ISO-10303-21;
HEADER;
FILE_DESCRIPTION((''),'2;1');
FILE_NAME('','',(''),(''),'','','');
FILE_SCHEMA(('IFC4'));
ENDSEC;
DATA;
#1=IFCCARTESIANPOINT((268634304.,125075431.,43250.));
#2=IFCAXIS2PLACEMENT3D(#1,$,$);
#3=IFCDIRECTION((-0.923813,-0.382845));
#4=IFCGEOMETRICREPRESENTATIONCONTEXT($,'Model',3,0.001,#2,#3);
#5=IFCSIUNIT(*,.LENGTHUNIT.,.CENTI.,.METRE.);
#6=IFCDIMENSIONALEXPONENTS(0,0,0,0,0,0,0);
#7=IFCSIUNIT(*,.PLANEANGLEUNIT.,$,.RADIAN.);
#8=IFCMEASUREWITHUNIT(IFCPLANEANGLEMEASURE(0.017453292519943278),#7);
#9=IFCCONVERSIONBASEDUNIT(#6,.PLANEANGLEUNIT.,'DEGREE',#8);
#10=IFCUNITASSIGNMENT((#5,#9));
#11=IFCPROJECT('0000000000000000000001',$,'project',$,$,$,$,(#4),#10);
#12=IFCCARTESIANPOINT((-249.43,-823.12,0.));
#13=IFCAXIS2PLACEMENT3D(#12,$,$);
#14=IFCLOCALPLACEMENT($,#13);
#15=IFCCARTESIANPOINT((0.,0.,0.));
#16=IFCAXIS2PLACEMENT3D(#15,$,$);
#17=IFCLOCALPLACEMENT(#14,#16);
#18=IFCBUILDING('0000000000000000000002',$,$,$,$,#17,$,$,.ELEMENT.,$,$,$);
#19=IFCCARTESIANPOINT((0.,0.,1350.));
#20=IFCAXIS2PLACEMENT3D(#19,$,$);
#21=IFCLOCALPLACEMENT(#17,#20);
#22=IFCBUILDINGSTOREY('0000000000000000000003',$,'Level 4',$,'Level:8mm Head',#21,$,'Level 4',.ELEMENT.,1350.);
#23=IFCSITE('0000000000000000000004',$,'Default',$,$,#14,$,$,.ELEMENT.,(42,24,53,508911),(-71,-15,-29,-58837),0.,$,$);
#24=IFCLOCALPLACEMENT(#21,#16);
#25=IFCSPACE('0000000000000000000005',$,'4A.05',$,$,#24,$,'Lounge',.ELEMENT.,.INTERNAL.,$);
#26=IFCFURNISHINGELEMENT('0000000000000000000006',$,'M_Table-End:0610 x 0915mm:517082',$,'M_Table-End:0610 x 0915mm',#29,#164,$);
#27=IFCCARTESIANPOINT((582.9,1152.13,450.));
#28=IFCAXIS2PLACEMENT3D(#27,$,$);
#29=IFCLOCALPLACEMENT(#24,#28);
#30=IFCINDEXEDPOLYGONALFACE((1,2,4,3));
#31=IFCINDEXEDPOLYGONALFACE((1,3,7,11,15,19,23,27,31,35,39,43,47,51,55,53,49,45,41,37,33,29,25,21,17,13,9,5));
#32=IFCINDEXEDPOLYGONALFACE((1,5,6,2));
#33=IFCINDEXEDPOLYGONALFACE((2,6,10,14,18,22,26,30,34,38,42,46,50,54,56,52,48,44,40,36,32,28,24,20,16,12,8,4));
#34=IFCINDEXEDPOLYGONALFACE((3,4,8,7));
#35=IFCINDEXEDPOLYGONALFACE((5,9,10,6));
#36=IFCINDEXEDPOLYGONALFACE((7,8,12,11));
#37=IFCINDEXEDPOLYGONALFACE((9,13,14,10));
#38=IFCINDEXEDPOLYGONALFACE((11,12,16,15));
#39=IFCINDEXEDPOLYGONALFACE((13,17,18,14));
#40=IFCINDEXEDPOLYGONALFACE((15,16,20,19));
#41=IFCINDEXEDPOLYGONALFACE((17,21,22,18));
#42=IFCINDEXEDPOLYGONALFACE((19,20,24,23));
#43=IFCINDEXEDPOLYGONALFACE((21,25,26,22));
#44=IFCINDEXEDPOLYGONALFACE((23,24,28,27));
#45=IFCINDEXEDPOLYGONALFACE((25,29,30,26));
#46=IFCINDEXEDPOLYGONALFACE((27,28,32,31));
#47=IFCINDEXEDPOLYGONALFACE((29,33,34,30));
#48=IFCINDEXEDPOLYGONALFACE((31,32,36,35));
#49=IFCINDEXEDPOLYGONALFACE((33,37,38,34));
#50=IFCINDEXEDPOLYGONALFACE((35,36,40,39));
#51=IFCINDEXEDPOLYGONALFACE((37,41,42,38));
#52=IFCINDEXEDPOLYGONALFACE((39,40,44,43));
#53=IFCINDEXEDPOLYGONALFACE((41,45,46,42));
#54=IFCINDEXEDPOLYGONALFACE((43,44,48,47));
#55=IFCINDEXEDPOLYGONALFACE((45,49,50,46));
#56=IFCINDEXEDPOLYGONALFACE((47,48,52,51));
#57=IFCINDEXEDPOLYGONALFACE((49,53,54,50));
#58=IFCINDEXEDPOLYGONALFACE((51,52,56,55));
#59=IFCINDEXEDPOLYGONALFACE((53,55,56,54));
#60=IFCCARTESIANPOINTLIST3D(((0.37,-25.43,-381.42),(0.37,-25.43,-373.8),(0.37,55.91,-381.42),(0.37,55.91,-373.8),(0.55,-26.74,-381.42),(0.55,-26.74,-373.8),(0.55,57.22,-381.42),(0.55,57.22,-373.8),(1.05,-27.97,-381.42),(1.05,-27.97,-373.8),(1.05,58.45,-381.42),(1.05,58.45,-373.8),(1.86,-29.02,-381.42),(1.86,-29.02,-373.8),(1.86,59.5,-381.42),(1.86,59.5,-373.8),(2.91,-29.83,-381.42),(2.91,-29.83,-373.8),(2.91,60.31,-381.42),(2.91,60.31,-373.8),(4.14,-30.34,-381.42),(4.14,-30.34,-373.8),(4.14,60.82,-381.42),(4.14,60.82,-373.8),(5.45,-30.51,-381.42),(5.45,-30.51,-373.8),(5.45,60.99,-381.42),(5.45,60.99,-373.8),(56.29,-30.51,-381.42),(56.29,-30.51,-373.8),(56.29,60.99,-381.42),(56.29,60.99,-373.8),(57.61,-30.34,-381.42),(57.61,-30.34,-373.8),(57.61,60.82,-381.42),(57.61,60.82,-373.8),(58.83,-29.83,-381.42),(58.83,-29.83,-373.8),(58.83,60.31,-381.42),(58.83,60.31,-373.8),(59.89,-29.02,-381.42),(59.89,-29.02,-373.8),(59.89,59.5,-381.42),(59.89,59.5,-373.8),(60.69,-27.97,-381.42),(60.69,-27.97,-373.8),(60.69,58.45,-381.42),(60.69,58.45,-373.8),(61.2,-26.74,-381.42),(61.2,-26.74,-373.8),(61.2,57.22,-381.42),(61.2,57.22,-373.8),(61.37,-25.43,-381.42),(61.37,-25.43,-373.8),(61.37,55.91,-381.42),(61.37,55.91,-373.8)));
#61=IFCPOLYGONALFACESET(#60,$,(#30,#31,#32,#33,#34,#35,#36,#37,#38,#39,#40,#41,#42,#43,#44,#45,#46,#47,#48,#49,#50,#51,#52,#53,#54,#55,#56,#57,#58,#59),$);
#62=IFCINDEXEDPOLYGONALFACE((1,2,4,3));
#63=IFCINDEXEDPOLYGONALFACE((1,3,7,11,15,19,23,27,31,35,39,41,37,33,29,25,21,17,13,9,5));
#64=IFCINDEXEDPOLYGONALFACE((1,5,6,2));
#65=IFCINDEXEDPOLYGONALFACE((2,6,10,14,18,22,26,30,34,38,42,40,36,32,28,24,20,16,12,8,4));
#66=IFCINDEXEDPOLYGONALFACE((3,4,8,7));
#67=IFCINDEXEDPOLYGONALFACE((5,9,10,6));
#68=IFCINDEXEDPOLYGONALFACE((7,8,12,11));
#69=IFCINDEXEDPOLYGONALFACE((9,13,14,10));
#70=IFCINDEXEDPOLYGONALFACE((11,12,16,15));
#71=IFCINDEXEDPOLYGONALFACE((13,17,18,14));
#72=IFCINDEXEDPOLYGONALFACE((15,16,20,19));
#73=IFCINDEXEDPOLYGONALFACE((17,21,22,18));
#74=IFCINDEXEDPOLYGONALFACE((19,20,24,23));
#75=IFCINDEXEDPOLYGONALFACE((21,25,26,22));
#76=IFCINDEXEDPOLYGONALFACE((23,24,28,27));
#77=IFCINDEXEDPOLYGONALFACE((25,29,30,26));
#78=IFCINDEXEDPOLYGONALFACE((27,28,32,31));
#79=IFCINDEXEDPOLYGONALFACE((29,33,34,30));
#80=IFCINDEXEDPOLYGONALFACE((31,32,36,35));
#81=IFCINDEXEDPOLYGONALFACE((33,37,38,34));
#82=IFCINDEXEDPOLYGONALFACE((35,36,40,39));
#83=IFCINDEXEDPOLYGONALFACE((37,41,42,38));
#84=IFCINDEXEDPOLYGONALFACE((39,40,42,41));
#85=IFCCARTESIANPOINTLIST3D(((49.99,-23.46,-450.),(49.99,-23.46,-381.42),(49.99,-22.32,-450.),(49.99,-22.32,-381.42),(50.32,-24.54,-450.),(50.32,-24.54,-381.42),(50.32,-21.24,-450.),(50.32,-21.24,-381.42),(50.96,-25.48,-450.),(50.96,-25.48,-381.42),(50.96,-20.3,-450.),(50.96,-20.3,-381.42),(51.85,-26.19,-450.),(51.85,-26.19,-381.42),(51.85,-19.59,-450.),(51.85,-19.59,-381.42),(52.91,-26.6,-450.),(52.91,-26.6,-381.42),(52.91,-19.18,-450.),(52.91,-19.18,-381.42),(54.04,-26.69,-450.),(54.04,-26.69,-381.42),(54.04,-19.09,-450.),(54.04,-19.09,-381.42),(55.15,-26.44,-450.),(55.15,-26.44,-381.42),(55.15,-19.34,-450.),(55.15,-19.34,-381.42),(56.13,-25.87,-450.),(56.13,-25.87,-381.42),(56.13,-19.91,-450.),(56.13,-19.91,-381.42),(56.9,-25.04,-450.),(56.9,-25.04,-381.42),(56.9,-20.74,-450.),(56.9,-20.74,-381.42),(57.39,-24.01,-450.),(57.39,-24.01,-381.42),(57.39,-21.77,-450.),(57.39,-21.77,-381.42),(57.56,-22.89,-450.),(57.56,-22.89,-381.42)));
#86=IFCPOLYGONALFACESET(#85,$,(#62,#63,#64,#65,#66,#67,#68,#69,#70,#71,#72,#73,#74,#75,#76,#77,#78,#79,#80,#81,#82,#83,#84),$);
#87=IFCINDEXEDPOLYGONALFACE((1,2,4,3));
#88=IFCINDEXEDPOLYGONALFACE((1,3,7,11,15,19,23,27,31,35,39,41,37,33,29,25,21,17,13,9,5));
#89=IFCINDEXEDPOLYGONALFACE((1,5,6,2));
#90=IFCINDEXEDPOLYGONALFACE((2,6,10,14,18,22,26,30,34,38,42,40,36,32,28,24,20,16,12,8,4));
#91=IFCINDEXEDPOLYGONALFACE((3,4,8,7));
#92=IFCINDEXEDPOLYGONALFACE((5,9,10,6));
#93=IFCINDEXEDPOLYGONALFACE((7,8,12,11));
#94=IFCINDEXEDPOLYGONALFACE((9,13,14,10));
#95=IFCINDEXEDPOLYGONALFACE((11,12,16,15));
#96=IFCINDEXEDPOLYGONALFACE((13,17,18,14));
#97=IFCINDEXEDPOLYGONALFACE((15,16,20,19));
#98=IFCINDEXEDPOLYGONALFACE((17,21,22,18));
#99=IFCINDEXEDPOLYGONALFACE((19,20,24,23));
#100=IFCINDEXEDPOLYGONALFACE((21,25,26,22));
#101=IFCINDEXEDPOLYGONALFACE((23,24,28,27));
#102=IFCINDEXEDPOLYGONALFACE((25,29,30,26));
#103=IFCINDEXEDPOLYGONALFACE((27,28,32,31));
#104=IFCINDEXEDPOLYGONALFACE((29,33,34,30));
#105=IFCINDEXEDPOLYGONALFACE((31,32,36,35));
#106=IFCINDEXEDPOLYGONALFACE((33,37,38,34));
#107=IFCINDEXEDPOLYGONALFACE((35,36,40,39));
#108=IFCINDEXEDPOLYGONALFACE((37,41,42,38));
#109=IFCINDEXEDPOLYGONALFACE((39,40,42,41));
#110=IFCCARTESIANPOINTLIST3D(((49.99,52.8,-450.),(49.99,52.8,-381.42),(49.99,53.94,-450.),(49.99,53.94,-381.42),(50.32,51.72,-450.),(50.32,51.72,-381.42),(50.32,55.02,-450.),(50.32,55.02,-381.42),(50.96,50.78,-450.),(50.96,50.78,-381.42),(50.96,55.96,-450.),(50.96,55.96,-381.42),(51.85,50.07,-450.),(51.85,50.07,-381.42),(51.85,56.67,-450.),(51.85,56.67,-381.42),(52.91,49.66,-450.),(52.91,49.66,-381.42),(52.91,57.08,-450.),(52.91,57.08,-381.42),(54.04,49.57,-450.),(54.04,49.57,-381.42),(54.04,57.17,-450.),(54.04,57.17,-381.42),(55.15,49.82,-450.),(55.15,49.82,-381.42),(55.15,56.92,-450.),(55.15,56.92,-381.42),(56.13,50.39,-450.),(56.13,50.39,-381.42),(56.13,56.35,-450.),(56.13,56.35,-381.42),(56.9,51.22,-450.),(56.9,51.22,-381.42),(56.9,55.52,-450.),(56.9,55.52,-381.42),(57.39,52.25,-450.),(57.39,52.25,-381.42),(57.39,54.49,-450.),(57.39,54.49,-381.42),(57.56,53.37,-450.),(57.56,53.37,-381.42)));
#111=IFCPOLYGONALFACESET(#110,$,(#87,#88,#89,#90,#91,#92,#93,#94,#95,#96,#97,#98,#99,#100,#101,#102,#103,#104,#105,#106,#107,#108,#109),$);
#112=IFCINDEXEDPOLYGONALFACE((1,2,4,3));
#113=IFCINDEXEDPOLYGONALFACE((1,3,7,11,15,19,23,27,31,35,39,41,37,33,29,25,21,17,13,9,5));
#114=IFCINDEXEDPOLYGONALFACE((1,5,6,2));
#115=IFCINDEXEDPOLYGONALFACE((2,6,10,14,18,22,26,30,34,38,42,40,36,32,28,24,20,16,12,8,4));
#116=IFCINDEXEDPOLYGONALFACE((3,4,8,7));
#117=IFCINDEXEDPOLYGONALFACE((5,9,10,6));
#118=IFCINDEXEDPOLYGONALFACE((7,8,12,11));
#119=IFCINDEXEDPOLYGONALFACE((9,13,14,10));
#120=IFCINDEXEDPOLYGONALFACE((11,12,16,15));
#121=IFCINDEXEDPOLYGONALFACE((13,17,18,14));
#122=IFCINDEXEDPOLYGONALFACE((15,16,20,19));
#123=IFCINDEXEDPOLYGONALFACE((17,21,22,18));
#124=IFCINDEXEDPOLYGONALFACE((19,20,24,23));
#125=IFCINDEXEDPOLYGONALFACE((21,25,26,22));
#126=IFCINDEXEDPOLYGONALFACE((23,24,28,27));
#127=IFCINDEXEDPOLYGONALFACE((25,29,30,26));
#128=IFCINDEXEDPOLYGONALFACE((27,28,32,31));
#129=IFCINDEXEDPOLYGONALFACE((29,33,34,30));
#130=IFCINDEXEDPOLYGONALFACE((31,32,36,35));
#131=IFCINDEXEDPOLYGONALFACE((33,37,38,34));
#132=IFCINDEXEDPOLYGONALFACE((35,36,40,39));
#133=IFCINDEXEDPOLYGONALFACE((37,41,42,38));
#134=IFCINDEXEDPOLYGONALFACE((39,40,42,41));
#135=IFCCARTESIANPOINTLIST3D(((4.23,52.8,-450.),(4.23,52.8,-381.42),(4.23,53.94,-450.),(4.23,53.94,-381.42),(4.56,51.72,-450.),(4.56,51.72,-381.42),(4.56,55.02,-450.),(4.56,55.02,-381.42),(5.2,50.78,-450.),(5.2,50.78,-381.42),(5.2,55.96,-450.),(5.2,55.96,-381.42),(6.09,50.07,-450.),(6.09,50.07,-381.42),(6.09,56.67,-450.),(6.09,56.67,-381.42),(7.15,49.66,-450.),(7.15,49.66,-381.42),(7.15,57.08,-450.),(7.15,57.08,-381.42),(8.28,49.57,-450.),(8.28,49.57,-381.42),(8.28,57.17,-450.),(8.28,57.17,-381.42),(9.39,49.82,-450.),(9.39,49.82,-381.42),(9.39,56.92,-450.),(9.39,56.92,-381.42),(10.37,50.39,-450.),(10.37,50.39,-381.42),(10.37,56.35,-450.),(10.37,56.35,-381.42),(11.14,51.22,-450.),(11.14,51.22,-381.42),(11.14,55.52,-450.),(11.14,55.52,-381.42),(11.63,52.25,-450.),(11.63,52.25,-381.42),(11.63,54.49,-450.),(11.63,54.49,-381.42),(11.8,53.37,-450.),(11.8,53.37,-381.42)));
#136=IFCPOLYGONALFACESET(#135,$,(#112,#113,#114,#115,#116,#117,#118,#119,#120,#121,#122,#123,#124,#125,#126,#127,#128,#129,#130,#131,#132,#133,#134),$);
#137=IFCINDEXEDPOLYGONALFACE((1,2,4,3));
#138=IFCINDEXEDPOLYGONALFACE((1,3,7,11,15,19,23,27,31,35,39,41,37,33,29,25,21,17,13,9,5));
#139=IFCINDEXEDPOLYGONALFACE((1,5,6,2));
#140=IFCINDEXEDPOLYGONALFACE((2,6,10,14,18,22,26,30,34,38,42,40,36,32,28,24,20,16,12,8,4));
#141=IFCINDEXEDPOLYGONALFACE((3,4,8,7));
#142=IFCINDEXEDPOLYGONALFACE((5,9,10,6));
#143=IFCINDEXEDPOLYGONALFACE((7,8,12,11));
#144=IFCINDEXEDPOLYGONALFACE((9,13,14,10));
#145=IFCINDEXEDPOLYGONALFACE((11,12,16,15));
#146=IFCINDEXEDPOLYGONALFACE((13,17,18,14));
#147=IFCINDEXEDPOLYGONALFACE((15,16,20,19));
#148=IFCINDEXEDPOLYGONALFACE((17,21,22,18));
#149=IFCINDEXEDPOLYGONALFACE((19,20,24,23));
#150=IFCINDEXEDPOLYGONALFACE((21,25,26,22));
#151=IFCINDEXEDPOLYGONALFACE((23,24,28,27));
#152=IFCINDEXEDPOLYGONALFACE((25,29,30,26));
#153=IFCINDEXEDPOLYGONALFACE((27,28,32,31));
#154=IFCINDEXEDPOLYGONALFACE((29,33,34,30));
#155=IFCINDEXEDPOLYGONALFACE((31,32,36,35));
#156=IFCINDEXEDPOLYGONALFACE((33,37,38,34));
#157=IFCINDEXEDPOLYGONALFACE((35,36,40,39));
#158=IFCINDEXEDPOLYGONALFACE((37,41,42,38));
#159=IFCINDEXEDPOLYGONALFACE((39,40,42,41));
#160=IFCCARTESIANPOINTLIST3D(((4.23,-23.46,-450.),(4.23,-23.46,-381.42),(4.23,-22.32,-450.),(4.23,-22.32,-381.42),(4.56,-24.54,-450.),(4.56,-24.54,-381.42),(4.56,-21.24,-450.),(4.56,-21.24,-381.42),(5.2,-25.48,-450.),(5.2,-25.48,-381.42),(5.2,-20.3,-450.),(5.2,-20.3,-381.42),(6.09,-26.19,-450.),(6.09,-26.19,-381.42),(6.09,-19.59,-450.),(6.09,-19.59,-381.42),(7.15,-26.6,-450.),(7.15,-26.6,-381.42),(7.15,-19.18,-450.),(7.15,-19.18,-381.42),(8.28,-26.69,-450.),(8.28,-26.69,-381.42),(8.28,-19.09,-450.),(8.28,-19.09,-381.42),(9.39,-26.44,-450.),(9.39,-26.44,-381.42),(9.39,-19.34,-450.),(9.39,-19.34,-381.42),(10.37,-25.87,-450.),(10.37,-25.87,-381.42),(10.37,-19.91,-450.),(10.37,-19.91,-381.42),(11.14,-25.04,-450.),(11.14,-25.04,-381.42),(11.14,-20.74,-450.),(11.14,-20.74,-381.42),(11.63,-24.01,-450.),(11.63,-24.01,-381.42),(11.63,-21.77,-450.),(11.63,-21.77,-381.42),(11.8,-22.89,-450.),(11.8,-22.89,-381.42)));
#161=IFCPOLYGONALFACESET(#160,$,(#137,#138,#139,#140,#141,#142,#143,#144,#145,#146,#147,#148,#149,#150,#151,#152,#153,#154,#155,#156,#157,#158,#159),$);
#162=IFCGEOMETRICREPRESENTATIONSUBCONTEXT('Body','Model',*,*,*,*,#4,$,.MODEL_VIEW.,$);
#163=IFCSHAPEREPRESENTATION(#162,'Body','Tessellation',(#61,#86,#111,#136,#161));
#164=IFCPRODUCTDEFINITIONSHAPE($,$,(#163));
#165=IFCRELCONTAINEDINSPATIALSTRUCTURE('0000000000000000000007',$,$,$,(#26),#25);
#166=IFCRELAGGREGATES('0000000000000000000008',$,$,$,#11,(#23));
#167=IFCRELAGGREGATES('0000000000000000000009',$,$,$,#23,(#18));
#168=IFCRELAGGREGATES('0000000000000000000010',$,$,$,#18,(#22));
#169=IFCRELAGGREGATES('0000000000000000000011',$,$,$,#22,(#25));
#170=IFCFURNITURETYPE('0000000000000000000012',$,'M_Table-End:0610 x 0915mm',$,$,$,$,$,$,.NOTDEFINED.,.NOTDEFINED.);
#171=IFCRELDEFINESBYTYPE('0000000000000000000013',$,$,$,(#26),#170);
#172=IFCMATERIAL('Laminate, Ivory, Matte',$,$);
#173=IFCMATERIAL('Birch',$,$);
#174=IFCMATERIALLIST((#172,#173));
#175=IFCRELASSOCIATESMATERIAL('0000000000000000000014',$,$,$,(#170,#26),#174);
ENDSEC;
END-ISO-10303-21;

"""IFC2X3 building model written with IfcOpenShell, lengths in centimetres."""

from ifc_helpers import new_model, entity, si_unit, converted_unit, direction, frame, frame_2d, origin, place, context, subcontext, project, spatial, polyline, circle_curve, parameter, trimmed, segment, composite_curve, circle, outline, extrude, source, transform, mapped, material, material_list, type_object, type_shapes, element, save


model = new_model("IFC2X3")

# Units and contexts
model_context = context("Model", 3, precision=0.001, world=frame((268634304.0, 125075431.0, 43250.0)), true_north=direction((-0.923813, -0.382845)))
body_context = subcontext(model_context, "Body", "Model", "MODEL_VIEW")
ifc_project = project(units=[si_unit("LENGTHUNIT", "METRE", prefix="CENTI"), converted_unit("PLANEANGLEUNIT", "DEGREE", entity("IfcPlaneAngleMeasure", 0.017453292519943278), si_unit("PLANEANGLEUNIT", "RADIAN"), dimensions=[0, 0, 0, 0, 0, 0, 0])], contexts=[model_context])

# Site, building, storey
site_placement = place(None, frame((-249.43, -823.12, 0.0)))
site = spatial("IfcSite", under=ifc_project, at=site_placement, Name="Default", CompositionType="ELEMENT", RefLatitude=(42, 24, 53, 508911), RefLongitude=(-71, -15, -29, -58837), RefElevation=0.0)
building_placement = place(site_placement, origin())
building = spatial("IfcBuilding", under=site, at=building_placement, CompositionType="ELEMENT")
storey_placement = place(building_placement, frame((0.0, 0.0, 1350.0)))
storey = spatial("IfcBuildingStorey", under=building, at=storey_placement, Name="Level 4", ObjectType="Level:8mm Head", LongName="Level 4", CompositionType="ELEMENT", Elevation=1350.0)

# Shared definitions
space_1_placement = place(storey_placement, origin())
space_1 = spatial("IfcSpace", under=storey, at=space_1_placement, Name="4A.05", LongName="Lounge", CompositionType="ELEMENT", InteriorOrExteriorSpace="INTERNAL")

# Furnishing element
ifc_material_1 = material(Name="Laminate, Ivory, Matte")
ifc_material_2 = material(Name="Birch")
ifc_material_list_1 = material_list([ifc_material_1, ifc_material_2])
furniture_type_1 = type_object("IfcFurnitureType", Name="M_Table-End:0610 x 0915mm", AssemblyPlace="NOTDEFINED", material=ifc_material_list_1)
shared_shape_1 = source(origin(), body_context, "Body", "SweptSolid", [
    extrude(outline(composite_curve([segment(trimmed(circle_curve(frame_2d((25.42, -40.67), x_axis=(1.0, 0.0)), 5.08), [parameter(270.0)], [parameter(0.0)], True, "PARAMETER"), True, "CONTINUOUS"), segment(polyline([(30.5, -40.67), (30.5, 40.67)]), True, "CONTINUOUS"), segment(trimmed(circle_curve(frame_2d((25.42, 40.67), x_axis=(1.0, 0.0)), 5.08), [parameter(360.0)], [parameter(90.0)], True, "PARAMETER"), True, "CONTINUOUS"), segment(polyline([(25.42, 45.75), (-25.42, 45.75)]), True, "CONTINUOUS"), segment(trimmed(circle_curve(frame_2d((-25.42, 40.67), x_axis=(1.0, 0.0)), 5.08), [parameter(90.0)], [parameter(180.0)], True, "PARAMETER"), True, "CONTINUOUS"), segment(polyline([(-30.5, 40.67), (-30.5, -40.67)]), True, "CONTINUOUS"), segment(trimmed(circle_curve(frame_2d((-25.42, -40.67), x_axis=(1.0, 0.0)), 5.08), [parameter(180.0)], [parameter(270.0)], True, "PARAMETER"), True, "CONTINUOUS"), segment(polyline([(-25.42, -45.75), (25.42, -45.75)]), True, "CONTINUOUS")], self_intersect=False)), frame((30.87, 15.24, -381.42)), (0.0, 0.0, 1.0), 7.62),
    extrude(circle(Radius=3.81, at=frame_2d((0.0, 0.0), x_axis=(1.0, 0.0))), frame((53.75, -22.89, -450.0)), (0.0, 0.0, 1.0), 68.58),
    extrude(circle(Radius=3.81, at=frame_2d((0.0, 0.0), x_axis=(1.0, 0.0))), frame((53.75, 53.37, -450.0)), (0.0, 0.0, 1.0), 68.58),
    extrude(circle(Radius=3.81, at=frame_2d((0.0, 0.0), x_axis=(1.0, 0.0))), frame((7.99, 53.37, -450.0)), (0.0, 0.0, 1.0), 68.58),
    extrude(circle(Radius=3.81, at=frame_2d((0.0, 0.0), x_axis=(1.0, 0.0))), frame((7.99, -22.89, -450.0)), (0.0, 0.0, 1.0), 68.58),
])
type_shapes(furniture_type_1, [shared_shape_1])
furnishing_1_placement = place(space_1_placement, frame((582.9, 1152.13, 450.0)))
element("IfcFurnishingElement", 1, at=furnishing_1_placement, inside=space_1, type_object=furniture_type_1, material=ifc_material_list_1, Name="M_Table-End:0610 x 0915mm:517082", ObjectType="M_Table-End:0610 x 0915mm", context=body_context, shape_type="MappedRepresentation", body=[
    mapped(shared_shape_1, transform((0.0, 0.0, 0.0), scale=1.0)),
])

save(model, "model.ifc")
